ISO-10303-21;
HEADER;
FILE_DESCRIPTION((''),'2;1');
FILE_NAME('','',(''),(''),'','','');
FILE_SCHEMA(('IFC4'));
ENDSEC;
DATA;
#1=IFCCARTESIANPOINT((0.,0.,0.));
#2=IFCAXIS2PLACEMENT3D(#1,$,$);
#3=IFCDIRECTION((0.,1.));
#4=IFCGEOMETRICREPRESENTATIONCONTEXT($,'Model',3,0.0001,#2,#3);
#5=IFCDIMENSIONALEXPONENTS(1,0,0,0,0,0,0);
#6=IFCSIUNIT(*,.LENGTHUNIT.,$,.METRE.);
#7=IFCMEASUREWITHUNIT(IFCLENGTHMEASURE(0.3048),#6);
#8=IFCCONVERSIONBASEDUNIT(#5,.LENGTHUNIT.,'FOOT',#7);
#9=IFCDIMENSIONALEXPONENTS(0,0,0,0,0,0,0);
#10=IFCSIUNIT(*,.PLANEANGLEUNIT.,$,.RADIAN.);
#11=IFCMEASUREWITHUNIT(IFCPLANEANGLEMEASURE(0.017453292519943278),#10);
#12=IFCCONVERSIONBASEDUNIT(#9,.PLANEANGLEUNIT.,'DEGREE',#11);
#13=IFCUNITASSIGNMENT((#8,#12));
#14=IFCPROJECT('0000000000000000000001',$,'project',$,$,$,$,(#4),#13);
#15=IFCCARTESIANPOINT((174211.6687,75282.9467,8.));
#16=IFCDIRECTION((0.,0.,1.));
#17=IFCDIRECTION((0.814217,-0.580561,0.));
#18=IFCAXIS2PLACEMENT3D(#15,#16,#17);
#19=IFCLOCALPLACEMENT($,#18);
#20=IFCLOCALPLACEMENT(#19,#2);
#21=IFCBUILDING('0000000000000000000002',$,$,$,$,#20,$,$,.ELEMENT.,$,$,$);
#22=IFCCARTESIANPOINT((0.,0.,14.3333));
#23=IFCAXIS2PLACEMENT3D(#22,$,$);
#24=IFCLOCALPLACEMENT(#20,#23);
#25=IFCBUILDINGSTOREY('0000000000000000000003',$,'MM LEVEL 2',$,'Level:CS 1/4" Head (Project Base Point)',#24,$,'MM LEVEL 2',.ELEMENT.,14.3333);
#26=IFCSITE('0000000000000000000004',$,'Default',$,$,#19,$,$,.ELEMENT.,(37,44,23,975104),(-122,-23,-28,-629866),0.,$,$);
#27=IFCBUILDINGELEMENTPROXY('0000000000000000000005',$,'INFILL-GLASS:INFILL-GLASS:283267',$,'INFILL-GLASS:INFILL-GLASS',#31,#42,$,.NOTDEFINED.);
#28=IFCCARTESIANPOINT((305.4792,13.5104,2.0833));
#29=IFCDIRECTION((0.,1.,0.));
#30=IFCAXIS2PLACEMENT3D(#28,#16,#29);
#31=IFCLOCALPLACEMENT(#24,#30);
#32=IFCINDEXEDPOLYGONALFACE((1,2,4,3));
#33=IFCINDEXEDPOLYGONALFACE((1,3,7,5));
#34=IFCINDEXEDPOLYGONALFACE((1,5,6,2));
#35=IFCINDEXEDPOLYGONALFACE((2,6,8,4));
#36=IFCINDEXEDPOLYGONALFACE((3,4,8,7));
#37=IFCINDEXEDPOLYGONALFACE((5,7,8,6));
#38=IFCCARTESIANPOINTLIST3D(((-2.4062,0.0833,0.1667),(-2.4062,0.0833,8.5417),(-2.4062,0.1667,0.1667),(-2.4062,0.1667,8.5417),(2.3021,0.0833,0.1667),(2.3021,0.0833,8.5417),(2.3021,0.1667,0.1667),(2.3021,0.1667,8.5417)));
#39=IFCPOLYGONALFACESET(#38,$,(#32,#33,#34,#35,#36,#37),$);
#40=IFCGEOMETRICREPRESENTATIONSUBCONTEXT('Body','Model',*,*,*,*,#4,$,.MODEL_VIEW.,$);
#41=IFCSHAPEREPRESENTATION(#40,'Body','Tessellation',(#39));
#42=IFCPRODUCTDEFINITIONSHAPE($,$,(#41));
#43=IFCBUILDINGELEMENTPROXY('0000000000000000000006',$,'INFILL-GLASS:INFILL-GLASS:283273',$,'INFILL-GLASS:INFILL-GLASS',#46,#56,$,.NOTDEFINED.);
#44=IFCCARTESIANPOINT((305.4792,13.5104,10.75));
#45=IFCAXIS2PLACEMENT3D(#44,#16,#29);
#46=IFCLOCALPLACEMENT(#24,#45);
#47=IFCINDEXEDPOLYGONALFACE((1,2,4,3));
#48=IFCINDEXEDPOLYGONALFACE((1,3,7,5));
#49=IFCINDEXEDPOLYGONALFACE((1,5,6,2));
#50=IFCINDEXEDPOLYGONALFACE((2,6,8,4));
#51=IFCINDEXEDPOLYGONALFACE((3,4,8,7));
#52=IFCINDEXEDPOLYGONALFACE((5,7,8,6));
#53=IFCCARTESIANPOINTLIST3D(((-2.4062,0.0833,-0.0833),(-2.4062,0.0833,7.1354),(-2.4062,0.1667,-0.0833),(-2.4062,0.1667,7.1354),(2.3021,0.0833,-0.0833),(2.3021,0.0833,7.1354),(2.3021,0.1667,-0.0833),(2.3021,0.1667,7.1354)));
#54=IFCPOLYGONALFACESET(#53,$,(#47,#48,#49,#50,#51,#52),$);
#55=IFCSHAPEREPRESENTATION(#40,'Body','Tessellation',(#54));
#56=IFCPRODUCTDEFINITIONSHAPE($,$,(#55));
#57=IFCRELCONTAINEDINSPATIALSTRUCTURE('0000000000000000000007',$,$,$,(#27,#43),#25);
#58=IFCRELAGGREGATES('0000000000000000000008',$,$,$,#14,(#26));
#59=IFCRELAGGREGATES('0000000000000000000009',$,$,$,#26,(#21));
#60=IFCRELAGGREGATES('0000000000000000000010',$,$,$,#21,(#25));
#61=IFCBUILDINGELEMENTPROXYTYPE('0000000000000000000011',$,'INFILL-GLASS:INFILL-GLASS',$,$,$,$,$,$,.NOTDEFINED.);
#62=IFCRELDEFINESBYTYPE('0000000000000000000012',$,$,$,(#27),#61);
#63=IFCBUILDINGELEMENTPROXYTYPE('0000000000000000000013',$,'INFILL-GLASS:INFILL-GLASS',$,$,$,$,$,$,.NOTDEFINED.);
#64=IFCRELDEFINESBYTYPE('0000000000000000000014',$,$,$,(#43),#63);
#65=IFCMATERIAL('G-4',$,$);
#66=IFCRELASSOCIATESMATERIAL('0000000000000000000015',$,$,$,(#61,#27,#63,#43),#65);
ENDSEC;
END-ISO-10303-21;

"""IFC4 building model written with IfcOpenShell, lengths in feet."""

from ifc_helpers import new_model, entity, si_unit, converted_unit, direction, frame, origin, place, context, subcontext, project, spatial, indexed_curve, outline, extrude, source, transform, mapped, material, type_object, type_shapes, element, save


model = new_model("IFC4")

# Units and contexts
model_context = context("Model", 3, precision=0.0001, world=origin(), true_north=direction((0.0, 1.0)))
body_context = subcontext(model_context, "Body", "Model", "MODEL_VIEW")
ifc_project = project(units=[converted_unit("LENGTHUNIT", "FOOT", entity("IfcLengthMeasure", 0.3048), si_unit("LENGTHUNIT", "METRE"), dimensions=[1, 0, 0, 0, 0, 0, 0]), converted_unit("PLANEANGLEUNIT", "DEGREE", entity("IfcPlaneAngleMeasure", 0.017453292519943278), si_unit("PLANEANGLEUNIT", "RADIAN"), dimensions=[0, 0, 0, 0, 0, 0, 0])], contexts=[model_context])

# Site, building, storey
site_placement = place(None, frame((174211.6687, 75282.9467, 8.0), z_axis=(0.0, 0.0, 1.0), x_axis=(0.814217, -0.580561, 0.0)))
site = spatial("IfcSite", under=ifc_project, at=site_placement, Name="Default", CompositionType="ELEMENT", RefLatitude=(37, 44, 23, 975104), RefLongitude=(-122, -23, -28, -629866), RefElevation=0.0)
building_placement = place(site_placement, origin())
building = spatial("IfcBuilding", under=site, at=building_placement, CompositionType="ELEMENT")
storey_placement = place(building_placement, frame((0.0, 0.0, 14.3333)))
storey = spatial("IfcBuildingStorey", under=building, at=storey_placement, Name="MM LEVEL 2", ObjectType="Level:CS 1/4\" Head (Project Base Point)", LongName="MM LEVEL 2", CompositionType="ELEMENT", Elevation=14.3333)

# Building element proxies
ifc_material_1 = material(Name="G-4")
building_element_proxy_type_1 = type_object("IfcBuildingElementProxyType", Name="INFILL-GLASS:INFILL-GLASS", PredefinedType="NOTDEFINED", material=ifc_material_1)
shared_shape_1 = source(origin(), body_context, "Body", "SweptSolid", [
    extrude(outline(indexed_curve([(-0.0417, -2.3542), (0.0417, -2.3542), (0.0417, 2.3542), (-0.0417, 2.3542), (-0.0417, -2.3542)], self_intersect=False)), frame((-0.0521, 0.125, 0.1667), z_axis=(0.0, 0.0, 1.0), x_axis=(0.0, 1.0, 0.0)), (0.0, 0.0, 1.0), 8.375),
])
type_shapes(building_element_proxy_type_1, [shared_shape_1])
proxy_1_placement = place(storey_placement, frame((305.4792, 13.5104, 2.0833), z_axis=(0.0, 0.0, 1.0), x_axis=(0.0, 1.0, 0.0)))
element("IfcBuildingElementProxy", 1, at=proxy_1_placement, inside=storey, type_object=building_element_proxy_type_1, material=ifc_material_1, Name="INFILL-GLASS:INFILL-GLASS:283267", ObjectType="INFILL-GLASS:INFILL-GLASS", PredefinedType="NOTDEFINED", context=body_context, shape_type="MappedRepresentation", body=[
    mapped(shared_shape_1, transform((0.0, 0.0, 0.0), scale=1.0)),
])
building_element_proxy_type_2 = type_object("IfcBuildingElementProxyType", Name="INFILL-GLASS:INFILL-GLASS", PredefinedType="NOTDEFINED", material=ifc_material_1)
shared_shape_2 = source(origin(), body_context, "Body", "SweptSolid", [
    extrude(outline(indexed_curve([(-0.0417, -2.3542), (0.0417, -2.3542), (0.0417, 2.3542), (-0.0417, 2.3542), (-0.0417, -2.3542)], self_intersect=False)), frame((-0.0521, 0.125, -0.0833), z_axis=(0.0, 0.0, 1.0), x_axis=(0.0, 1.0, 0.0)), (0.0, 0.0, 1.0), 7.2187),
])
type_shapes(building_element_proxy_type_2, [shared_shape_2])
proxy_2_placement = place(storey_placement, frame((305.4792, 13.5104, 10.75), z_axis=(0.0, 0.0, 1.0), x_axis=(0.0, 1.0, 0.0)))
element("IfcBuildingElementProxy", 2, at=proxy_2_placement, inside=storey, type_object=building_element_proxy_type_2, material=ifc_material_1, Name="INFILL-GLASS:INFILL-GLASS:283273", ObjectType="INFILL-GLASS:INFILL-GLASS", PredefinedType="NOTDEFINED", context=body_context, shape_type="MappedRepresentation", body=[
    mapped(shared_shape_2, transform((0.0, 0.0, 0.0), scale=1.0)),
])

save(model, "model.ifc")
